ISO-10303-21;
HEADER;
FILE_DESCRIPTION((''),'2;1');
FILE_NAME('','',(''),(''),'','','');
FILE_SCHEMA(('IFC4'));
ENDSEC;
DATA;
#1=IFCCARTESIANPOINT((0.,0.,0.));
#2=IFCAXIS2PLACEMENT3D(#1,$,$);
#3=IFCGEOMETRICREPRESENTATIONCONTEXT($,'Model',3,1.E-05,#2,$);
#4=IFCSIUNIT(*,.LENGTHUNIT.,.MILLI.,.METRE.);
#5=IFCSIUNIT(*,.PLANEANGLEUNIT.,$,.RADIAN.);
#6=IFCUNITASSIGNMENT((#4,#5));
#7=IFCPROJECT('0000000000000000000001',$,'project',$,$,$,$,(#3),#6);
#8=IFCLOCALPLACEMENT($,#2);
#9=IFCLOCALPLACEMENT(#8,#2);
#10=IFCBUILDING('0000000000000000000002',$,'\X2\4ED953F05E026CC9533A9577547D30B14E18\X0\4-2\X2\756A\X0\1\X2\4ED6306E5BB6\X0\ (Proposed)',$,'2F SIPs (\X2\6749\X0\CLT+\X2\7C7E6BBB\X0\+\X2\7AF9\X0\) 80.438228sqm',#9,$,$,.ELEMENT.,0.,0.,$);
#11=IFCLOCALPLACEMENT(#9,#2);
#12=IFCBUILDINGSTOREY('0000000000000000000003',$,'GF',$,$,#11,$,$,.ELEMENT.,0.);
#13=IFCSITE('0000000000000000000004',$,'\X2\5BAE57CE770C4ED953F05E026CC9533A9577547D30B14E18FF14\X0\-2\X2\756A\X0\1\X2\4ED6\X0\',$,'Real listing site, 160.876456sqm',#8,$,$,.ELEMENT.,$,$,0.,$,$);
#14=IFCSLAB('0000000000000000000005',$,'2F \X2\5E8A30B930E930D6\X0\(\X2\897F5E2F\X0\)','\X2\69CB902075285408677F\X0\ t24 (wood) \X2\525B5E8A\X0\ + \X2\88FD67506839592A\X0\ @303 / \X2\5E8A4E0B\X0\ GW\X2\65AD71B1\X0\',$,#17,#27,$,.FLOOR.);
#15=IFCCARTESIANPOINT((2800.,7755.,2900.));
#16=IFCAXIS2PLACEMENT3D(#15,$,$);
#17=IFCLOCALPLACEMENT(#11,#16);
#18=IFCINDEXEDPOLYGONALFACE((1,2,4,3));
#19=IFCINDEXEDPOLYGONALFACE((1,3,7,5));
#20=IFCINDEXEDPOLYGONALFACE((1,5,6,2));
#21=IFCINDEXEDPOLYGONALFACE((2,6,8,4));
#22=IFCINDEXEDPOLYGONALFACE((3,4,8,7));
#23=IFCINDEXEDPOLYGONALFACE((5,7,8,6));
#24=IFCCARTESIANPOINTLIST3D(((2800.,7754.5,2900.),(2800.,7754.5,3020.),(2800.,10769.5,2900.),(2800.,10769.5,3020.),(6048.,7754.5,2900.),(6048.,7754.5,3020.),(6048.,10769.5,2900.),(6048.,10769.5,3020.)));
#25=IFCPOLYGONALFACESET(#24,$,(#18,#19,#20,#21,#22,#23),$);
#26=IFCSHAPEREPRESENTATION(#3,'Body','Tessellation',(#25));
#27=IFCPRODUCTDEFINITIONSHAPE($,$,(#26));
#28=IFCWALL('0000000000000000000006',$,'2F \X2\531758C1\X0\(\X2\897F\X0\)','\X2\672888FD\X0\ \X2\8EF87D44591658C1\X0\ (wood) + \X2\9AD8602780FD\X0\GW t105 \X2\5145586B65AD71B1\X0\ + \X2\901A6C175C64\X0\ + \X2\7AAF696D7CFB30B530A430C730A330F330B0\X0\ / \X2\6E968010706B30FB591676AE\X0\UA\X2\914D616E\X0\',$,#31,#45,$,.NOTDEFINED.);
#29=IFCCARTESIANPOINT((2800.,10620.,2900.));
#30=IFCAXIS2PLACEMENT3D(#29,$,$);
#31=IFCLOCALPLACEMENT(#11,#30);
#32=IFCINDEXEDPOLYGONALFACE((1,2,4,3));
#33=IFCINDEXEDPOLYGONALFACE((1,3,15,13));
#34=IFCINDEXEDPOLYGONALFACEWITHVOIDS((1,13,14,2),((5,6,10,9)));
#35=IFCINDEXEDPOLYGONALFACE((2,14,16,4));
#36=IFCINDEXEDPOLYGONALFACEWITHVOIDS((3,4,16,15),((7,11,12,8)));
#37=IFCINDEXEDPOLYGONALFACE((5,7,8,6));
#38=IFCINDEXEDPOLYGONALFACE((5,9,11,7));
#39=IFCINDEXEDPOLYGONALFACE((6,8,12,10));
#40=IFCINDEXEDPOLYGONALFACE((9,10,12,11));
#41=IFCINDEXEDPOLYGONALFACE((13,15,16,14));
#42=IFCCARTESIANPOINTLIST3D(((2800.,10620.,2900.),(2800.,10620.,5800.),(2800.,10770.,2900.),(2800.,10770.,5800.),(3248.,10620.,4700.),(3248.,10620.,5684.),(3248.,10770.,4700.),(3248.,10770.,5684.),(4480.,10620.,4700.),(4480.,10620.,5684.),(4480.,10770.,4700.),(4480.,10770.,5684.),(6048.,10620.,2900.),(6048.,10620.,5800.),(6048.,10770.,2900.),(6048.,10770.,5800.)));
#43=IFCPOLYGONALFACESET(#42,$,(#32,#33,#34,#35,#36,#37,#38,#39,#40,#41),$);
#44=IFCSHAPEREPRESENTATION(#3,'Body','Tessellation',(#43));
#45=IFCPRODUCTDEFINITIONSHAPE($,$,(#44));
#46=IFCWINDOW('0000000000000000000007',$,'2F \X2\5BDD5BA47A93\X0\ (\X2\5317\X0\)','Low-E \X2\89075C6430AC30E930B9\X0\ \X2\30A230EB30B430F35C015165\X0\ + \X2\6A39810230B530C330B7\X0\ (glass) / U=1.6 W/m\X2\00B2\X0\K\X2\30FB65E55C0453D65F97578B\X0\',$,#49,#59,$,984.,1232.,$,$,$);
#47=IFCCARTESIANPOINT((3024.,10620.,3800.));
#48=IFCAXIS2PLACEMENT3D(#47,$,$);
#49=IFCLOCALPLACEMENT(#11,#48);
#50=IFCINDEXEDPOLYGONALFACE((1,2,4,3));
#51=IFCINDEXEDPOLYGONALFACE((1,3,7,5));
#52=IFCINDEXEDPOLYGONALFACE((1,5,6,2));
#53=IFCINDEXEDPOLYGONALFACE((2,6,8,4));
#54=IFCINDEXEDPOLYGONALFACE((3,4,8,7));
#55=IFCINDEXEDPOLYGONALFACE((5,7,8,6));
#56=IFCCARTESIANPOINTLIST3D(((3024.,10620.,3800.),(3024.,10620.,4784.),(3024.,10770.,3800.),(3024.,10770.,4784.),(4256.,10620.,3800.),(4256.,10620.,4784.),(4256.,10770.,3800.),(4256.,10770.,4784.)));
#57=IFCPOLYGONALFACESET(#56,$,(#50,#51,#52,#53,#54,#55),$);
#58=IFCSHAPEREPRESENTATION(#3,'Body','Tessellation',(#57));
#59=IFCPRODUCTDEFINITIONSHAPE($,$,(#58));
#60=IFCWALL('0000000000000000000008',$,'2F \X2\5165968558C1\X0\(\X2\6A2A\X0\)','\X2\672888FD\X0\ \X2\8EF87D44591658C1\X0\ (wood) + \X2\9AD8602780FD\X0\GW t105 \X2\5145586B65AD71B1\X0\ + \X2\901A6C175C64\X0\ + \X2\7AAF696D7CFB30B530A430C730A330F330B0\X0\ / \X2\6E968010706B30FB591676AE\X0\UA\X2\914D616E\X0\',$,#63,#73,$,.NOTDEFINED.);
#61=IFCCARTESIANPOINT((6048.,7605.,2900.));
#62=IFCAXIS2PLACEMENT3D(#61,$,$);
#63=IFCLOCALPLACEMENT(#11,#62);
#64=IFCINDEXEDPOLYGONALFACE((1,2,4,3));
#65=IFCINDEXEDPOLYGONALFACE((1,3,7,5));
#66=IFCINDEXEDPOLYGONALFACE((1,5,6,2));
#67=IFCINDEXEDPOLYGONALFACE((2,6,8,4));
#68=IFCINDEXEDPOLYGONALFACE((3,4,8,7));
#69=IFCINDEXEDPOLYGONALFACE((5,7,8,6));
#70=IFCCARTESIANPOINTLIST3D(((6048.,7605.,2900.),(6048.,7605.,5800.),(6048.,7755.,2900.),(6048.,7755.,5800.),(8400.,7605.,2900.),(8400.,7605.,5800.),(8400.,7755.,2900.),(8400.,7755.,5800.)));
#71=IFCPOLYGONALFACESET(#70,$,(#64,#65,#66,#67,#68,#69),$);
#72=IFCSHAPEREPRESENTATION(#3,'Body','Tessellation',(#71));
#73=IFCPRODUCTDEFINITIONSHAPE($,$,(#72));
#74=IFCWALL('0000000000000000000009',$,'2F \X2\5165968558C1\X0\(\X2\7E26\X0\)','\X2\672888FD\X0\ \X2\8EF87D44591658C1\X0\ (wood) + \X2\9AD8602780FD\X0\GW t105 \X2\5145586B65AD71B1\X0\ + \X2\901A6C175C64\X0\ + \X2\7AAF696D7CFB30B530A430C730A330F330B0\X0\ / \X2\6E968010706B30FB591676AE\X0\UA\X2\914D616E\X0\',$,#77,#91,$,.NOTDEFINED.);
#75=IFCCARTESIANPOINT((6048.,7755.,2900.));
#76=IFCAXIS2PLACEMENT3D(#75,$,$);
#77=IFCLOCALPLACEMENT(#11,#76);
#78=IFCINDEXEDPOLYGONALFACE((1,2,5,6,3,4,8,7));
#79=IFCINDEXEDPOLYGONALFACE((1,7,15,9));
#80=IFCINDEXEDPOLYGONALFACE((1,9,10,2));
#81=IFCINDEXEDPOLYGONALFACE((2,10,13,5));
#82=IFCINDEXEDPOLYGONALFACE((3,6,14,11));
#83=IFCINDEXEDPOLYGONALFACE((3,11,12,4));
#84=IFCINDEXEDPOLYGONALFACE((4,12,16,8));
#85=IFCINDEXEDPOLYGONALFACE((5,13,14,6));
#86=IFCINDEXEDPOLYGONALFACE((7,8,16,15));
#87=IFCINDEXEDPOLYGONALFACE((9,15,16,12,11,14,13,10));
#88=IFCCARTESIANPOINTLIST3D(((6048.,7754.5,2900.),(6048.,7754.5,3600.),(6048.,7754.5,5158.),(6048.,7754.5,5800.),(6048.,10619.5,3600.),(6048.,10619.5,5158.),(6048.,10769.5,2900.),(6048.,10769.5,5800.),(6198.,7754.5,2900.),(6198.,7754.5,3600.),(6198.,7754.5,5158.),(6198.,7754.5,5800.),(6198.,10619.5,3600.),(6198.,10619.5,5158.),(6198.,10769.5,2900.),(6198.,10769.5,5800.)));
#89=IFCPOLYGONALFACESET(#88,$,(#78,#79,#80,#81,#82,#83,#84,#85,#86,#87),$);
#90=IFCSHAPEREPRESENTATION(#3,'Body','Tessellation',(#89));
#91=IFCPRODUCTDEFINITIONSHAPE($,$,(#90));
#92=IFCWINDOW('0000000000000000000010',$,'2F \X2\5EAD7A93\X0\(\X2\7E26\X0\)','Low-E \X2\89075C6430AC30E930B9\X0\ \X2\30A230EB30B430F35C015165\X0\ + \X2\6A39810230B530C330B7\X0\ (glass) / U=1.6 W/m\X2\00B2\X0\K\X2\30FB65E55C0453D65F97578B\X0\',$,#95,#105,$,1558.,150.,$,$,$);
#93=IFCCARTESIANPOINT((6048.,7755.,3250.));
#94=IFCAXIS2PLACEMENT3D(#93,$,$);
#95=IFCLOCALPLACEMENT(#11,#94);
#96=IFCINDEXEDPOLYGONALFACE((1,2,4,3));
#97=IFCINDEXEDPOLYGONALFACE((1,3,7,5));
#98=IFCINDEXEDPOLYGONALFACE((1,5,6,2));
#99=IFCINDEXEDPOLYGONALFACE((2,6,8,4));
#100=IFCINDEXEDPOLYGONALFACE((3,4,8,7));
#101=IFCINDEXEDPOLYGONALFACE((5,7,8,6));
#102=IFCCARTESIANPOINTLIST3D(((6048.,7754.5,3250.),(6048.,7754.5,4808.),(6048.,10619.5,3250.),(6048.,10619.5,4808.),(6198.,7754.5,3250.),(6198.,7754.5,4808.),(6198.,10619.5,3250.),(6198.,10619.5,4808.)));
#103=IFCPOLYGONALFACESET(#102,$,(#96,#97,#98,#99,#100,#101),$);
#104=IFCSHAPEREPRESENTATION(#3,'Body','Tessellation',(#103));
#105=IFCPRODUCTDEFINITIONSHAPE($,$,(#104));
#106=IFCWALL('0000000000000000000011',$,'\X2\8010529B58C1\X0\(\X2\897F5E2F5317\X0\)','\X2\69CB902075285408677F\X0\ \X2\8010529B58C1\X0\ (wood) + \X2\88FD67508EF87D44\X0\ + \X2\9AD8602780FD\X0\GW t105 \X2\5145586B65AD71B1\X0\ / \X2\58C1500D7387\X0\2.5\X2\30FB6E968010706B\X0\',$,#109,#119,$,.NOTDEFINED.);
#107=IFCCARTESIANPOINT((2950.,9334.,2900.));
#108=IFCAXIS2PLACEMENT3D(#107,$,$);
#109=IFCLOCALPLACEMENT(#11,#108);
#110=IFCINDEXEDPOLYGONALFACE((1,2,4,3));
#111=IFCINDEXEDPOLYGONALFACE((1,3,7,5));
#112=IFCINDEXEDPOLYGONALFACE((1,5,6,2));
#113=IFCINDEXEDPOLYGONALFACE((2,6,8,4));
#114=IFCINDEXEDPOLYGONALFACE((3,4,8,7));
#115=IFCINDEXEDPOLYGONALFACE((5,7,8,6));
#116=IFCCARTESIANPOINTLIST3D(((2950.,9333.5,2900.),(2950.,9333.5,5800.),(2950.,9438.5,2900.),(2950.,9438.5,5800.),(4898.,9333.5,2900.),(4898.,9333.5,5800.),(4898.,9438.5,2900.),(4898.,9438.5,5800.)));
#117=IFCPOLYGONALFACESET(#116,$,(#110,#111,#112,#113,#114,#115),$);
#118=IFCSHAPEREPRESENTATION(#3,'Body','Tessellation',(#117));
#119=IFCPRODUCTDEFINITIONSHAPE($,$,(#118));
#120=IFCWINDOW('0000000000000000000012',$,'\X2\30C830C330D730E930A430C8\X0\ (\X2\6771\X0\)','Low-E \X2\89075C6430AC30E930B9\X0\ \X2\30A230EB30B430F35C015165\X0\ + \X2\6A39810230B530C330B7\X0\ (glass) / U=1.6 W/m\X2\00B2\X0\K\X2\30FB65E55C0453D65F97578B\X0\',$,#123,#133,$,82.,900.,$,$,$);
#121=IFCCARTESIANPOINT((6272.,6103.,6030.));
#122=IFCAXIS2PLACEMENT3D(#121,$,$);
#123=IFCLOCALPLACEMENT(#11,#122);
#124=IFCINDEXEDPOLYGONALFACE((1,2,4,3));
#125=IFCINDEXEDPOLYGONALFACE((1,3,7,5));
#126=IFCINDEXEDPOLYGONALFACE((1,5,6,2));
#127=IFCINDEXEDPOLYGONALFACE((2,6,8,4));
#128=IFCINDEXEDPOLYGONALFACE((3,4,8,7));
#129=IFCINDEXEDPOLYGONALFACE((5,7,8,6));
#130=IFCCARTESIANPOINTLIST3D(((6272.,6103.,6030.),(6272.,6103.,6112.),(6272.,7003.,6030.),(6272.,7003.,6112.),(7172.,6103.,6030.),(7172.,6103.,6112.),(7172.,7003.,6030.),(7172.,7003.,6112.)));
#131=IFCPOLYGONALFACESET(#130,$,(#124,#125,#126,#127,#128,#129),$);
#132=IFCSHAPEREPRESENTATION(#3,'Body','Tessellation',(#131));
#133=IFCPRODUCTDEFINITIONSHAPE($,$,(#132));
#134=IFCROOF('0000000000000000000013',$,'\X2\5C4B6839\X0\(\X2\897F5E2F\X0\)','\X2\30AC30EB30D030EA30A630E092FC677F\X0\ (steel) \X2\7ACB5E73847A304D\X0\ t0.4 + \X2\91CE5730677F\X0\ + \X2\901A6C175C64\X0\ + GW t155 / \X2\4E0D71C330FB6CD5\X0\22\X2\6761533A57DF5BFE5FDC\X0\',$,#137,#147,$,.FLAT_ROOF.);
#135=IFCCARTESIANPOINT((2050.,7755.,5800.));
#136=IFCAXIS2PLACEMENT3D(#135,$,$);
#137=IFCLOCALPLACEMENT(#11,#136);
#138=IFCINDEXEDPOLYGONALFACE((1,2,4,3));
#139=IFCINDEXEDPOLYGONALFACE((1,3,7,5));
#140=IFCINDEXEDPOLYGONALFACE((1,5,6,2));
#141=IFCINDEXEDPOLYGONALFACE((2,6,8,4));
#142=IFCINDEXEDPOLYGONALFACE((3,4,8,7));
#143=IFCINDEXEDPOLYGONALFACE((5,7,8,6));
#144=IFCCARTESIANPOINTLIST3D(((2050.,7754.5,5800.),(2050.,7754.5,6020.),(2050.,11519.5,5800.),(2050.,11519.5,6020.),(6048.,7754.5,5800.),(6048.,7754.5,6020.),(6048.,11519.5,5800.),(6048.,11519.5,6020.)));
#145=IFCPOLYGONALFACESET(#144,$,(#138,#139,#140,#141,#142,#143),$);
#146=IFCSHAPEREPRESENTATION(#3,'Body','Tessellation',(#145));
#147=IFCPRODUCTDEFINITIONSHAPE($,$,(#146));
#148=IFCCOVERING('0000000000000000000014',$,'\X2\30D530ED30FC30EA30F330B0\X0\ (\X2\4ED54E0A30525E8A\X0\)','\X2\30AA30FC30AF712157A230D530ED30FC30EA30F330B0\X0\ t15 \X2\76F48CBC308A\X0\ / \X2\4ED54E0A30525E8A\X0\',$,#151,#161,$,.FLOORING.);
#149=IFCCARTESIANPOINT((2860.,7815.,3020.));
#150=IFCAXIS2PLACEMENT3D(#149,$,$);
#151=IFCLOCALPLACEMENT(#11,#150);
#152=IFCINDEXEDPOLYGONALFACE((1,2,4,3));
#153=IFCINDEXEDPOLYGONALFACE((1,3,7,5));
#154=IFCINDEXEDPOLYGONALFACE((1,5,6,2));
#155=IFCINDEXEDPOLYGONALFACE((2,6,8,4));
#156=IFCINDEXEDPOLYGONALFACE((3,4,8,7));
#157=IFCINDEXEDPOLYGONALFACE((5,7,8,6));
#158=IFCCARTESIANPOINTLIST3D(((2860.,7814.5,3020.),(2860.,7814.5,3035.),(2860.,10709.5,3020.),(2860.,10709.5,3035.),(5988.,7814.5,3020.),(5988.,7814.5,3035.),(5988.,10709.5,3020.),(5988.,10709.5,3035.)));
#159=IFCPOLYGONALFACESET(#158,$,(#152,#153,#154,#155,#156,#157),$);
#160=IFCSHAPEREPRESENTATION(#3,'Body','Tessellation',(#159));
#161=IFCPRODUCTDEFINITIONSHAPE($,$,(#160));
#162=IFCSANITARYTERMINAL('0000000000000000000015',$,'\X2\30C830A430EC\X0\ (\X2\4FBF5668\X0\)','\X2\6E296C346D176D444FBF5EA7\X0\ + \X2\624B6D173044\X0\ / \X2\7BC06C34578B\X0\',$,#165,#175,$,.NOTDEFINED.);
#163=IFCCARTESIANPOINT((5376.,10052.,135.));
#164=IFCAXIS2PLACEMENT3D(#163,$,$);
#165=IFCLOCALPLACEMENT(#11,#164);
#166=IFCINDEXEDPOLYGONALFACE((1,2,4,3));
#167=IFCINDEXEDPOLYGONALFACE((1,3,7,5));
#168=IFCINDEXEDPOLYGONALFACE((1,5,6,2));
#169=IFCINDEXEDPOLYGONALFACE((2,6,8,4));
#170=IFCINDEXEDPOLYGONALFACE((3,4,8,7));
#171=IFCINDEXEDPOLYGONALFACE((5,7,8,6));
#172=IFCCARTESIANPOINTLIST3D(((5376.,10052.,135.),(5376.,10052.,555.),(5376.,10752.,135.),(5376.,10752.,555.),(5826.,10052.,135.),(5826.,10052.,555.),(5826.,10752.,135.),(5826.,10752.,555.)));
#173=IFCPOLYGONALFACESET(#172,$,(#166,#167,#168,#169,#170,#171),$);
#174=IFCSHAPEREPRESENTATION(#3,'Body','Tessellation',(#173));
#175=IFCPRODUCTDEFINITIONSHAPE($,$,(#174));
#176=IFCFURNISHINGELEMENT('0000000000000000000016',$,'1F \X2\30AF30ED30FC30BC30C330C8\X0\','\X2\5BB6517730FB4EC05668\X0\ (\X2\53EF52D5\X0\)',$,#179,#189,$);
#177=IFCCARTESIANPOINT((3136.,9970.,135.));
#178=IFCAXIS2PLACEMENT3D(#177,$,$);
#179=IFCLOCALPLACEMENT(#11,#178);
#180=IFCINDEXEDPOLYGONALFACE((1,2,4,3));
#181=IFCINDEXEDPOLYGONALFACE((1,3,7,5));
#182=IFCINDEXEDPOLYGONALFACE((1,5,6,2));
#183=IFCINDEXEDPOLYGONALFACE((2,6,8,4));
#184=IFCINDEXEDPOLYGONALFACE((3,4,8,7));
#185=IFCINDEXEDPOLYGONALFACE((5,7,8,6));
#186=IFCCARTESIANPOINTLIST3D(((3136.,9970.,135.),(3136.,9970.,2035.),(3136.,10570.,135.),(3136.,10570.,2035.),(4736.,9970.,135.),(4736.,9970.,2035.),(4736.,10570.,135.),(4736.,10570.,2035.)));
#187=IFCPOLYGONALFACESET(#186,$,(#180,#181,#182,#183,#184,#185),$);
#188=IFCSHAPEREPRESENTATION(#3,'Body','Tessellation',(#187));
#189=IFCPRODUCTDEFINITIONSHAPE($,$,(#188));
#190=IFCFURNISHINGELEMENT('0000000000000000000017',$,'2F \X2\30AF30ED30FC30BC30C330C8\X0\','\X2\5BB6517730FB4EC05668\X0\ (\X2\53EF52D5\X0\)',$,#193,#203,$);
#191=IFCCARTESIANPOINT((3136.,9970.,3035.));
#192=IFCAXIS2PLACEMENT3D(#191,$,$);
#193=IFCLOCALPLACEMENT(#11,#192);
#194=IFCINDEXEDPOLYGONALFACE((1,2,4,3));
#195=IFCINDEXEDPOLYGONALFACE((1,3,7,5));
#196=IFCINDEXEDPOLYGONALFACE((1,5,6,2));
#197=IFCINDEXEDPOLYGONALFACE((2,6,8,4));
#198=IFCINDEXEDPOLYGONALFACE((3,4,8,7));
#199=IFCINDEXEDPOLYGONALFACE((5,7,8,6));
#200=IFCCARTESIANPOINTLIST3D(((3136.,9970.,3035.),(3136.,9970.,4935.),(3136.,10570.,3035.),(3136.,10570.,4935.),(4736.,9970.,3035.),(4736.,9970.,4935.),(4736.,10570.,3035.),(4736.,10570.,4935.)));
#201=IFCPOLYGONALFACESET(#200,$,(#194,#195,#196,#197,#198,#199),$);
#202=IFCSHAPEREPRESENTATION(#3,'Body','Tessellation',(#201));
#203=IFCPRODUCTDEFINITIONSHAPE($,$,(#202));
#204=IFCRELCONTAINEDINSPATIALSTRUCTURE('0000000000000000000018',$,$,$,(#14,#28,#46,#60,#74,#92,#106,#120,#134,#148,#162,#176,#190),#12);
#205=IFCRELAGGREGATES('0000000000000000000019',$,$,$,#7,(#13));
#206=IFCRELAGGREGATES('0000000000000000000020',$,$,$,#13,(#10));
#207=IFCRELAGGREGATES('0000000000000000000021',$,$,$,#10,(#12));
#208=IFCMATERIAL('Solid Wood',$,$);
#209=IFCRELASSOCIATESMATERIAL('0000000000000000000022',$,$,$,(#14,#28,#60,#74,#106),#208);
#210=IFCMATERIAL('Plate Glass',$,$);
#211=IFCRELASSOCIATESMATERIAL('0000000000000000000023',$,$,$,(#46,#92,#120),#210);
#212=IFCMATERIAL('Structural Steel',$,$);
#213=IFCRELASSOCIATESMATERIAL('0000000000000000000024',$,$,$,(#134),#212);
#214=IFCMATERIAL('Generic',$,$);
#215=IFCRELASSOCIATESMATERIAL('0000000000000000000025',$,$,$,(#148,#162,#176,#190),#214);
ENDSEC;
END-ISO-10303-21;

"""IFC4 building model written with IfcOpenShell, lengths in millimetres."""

from ifc_helpers import new_model, si_unit, frame, frame_2d, origin, place, context, project, spatial, rectangle, extrude, material, element, fill, save


model = new_model("IFC4")

# Units and contexts
model_context = context("Model", 3, precision=1e-05, world=origin())
ifc_project = project(units=[si_unit("LENGTHUNIT", "METRE", prefix="MILLI"), si_unit("PLANEANGLEUNIT", "RADIAN")], contexts=[model_context])

# Site, building, storey
site_placement = place(None, origin())
site = spatial("IfcSite", under=ifc_project, at=site_placement, Name="宮城県仙台市泉区長命ケ丘４-2番1他", ObjectType="Real listing site, 160.876456sqm", CompositionType="ELEMENT", RefElevation=0.0)
building_placement = place(site_placement, origin())
building = spatial("IfcBuilding", under=site, at=building_placement, Name="仙台市泉区長命ケ丘4-2番1他の家 (Proposed)", ObjectType="2F SIPs (杉CLT+籾殻+竹) 80.438228sqm", CompositionType="ELEMENT", ElevationOfRefHeight=0.0, ElevationOfTerrain=0.0)
storey_placement = place(building_placement, origin())
storey = spatial("IfcBuildingStorey", under=building, at=storey_placement, Name="GF", CompositionType="ELEMENT", Elevation=0.0)

# Slab
ifc_material_1 = material(Name="Solid Wood")
slab_placement = place(storey_placement, frame((2800.0, 7755.0, 2900.0)))
element("IfcSlab", 1, at=slab_placement, inside=storey, material=ifc_material_1, Name="2F 床スラブ(西帯)", Description="構造用合板 t24 (wood) 剛床 + 製材根太 @303 / 床下 GW断熱", PredefinedType="FLOOR", context=model_context, shape_type="SweptSolid", body=[
    extrude(rectangle(XDim=3248.0, YDim=3015.0, at=frame_2d((1624.0, 1507.0))), frame((2800.0, 7755.0, 2900.0)), (0.0, 0.0, 1.0), 120.0),
])

# Wall, opening, window
wall_1_placement = place(storey_placement, frame((2800.0, 10620.0, 2900.0)))
wall_1 = element("IfcWall", 2, at=wall_1_placement, inside=storey, material=ifc_material_1, Name="2F 北壁(西)", Description="木製 軸組外壁 (wood) + 高性能GW t105 充填断熱 + 通気層 + 窯業系サイディング / 準耐火・外皮UA配慮", PredefinedType="NOTDEFINED", context=model_context, shape_type="SweptSolid", body=[
    extrude(rectangle(XDim=3248.0, YDim=150.0, at=frame_2d((1624.0, 75.0))), frame((2800.0, 10620.0, 2900.0)), (0.0, 0.0, 1.0), 2900.0),
])
opening_1_placement = place(storey_placement, frame((3024.0, 10620.0, 3800.0)))
opening_1 = element("IfcOpeningElement", 3, at=opening_1_placement, cuts=wall_1, PredefinedType="NOTDEFINED", context=model_context, shape_type="SweptSolid", body=[
    extrude(rectangle(XDim=1232.0, YDim=150.0, at=frame_2d((616.0, 75.0))), frame((3024.0, 10620.0, 3800.0)), (0.0, 0.0, 1.0), 984.0),
])
ifc_material_2 = material(Name="Plate Glass")
window_1_placement = place(storey_placement, frame((3024.0, 10620.0, 3800.0)))
window_1 = element("IfcWindow", 4, at=window_1_placement, inside=storey, material=ifc_material_2, Name="2F 寝室窓 (北)", Description="Low-E 複層ガラス アルゴン封入 + 樹脂サッシ (glass) / U=1.6 W/m²K・日射取得型", OverallHeight=984.0, OverallWidth=1232.0, context=model_context, shape_type="SweptSolid", body=[
    extrude(rectangle(XDim=1232.0, YDim=150.0, at=frame_2d((616.0, 75.0))), frame((3024.0, 10620.0, 3800.0)), (0.0, 0.0, 1.0), 984.0),
])
fill(opening_1, window_1)

# Wall
wall_2_placement = place(storey_placement, frame((6048.0, 7605.0, 2900.0)))
element("IfcWall", 5, at=wall_2_placement, inside=storey, material=ifc_material_1, Name="2F 入隅壁(横)", Description="木製 軸組外壁 (wood) + 高性能GW t105 充填断熱 + 通気層 + 窯業系サイディング / 準耐火・外皮UA配慮", PredefinedType="NOTDEFINED", context=model_context, shape_type="SweptSolid", body=[
    extrude(rectangle(XDim=2352.0, YDim=150.0, at=frame_2d((1176.0, 75.0))), frame((6048.0, 7605.0, 2900.0)), (0.0, 0.0, 1.0), 2900.0),
])

# Wall, opening, window
wall_3_placement = place(storey_placement, frame((6048.0, 7755.0, 2900.0)))
wall_3 = element("IfcWall", 6, at=wall_3_placement, inside=storey, material=ifc_material_1, Name="2F 入隅壁(縦)", Description="木製 軸組外壁 (wood) + 高性能GW t105 充填断熱 + 通気層 + 窯業系サイディング / 準耐火・外皮UA配慮", PredefinedType="NOTDEFINED", context=model_context, shape_type="SweptSolid", body=[
    extrude(rectangle(XDim=150.0, YDim=3015.0, at=frame_2d((75.0, 1507.0))), frame((6048.0, 7755.0, 2900.0)), (0.0, 0.0, 1.0), 2900.0),
])
opening_2_placement = place(storey_placement, frame((6048.0, 7755.0, 3250.0)))
opening_2 = element("IfcOpeningElement", 7, at=opening_2_placement, cuts=wall_3, PredefinedType="NOTDEFINED", context=model_context, shape_type="SweptSolid", body=[
    extrude(rectangle(XDim=150.0, YDim=2865.0, at=frame_2d((75.0, 1432.0))), frame((6048.0, 7755.0, 3250.0)), (0.0, 0.0, 1.0), 1558.0),
])
window_2_placement = place(storey_placement, frame((6048.0, 7755.0, 3250.0)))
window_2 = element("IfcWindow", 8, at=window_2_placement, inside=storey, material=ifc_material_2, Name="2F 庭窓(縦)", Description="Low-E 複層ガラス アルゴン封入 + 樹脂サッシ (glass) / U=1.6 W/m²K・日射取得型", OverallHeight=1558.0, OverallWidth=150.0, context=model_context, shape_type="SweptSolid", body=[
    extrude(rectangle(XDim=150.0, YDim=2865.0, at=frame_2d((75.0, 1432.0))), frame((6048.0, 7755.0, 3250.0)), (0.0, 0.0, 1.0), 1558.0),
])
fill(opening_2, window_2)

# Wall
wall_4_placement = place(storey_placement, frame((2950.0, 9334.0, 2900.0)))
element("IfcWall", 9, at=wall_4_placement, inside=storey, material=ifc_material_1, Name="耐力壁(西帯北)", Description="構造用合板 耐力壁 (wood) + 製材軸組 + 高性能GW t105 充填断熱 / 壁倍率2.5・準耐火", PredefinedType="NOTDEFINED", context=model_context, shape_type="SweptSolid", body=[
    extrude(rectangle(XDim=1948.0, YDim=105.0, at=frame_2d((974.0, 52.0))), frame((2950.0, 9334.0, 2900.0)), (0.0, 0.0, 1.0), 2900.0),
])

# Window
window_3_placement = place(storey_placement, frame((6272.0, 6103.0, 6030.0)))
element("IfcWindow", 10, at=window_3_placement, inside=storey, material=ifc_material_2, Name="トップライト (東)", Description="Low-E 複層ガラス アルゴン封入 + 樹脂サッシ (glass) / U=1.6 W/m²K・日射取得型", OverallHeight=82.0, OverallWidth=900.0, context=model_context, shape_type="SweptSolid", body=[
    extrude(rectangle(XDim=900.0, YDim=900.0, at=frame_2d((450.0, 450.0))), frame((6272.0, 6103.0, 6030.0)), (0.0, 0.0, 1.0), 82.0),
])

# Roof
ifc_material_3 = material(Name="Structural Steel")
for number, where, name in (
    (11, (2050.0, 7755.0, 5800.0), "屋根(西帯)"),
):
    element("IfcRoof", number, at=place(storey_placement, frame(where)), inside=storey, material=ifc_material_3, Name=name, Description="ガルバリウム鋼板 (steel) 立平葺き t0.4 + 野地板 + 通気層 + GW t155 / 不燃・法22条区域対応", PredefinedType="FLAT_ROOF", context=model_context, shape_type="SweptSolid", body=[
        extrude(rectangle(XDim=3998.0, YDim=3765.0, at=frame_2d((1999.0, 1882.0))), frame((2050.0, 7755.0, 5800.0)), (0.0, 0.0, 1.0), 220.0),
    ])

# Covering
ifc_material_4 = material(Name="Generic")
covering_placement = place(storey_placement, frame((2860.0, 7815.0, 3020.0)))
element("IfcCovering", 12, at=covering_placement, inside=storey, material=ifc_material_4, Name="フローリング (仕上げ床)", Description="オーク無垢フローリング t15 直貼り / 仕上げ床", PredefinedType="FLOORING", context=model_context, shape_type="SweptSolid", body=[
    extrude(rectangle(XDim=3128.0, YDim=2895.0, at=frame_2d((1564.0, 1447.0))), frame((2860.0, 7815.0, 3020.0)), (0.0, 0.0, 1.0), 15.0),
])

# Sanitary terminal
sanitary_terminal_placement = place(storey_placement, frame((5376.0, 10052.0, 135.0)))
element("IfcSanitaryTerminal", 13, at=sanitary_terminal_placement, inside=storey, material=ifc_material_4, Name="トイレ (便器)", Description="温水洗浄便座 + 手洗い / 節水型", PredefinedType="NOTDEFINED", context=model_context, shape_type="SweptSolid", body=[
    extrude(rectangle(XDim=450.0, YDim=700.0, at=frame_2d((225.0, 350.0))), frame((5376.0, 10052.0, 135.0)), (0.0, 0.0, 1.0), 420.0),
])

# Furnishing elements
furnishing_1_placement = place(storey_placement, frame((3136.0, 9970.0, 135.0)))
element("IfcFurnishingElement", 14, at=furnishing_1_placement, inside=storey, material=ifc_material_4, Name="1F クローゼット", Description="家具・什器 (可動)", context=model_context, shape_type="SweptSolid", body=[
    extrude(rectangle(XDim=1600.0, YDim=600.0, at=frame_2d((800.0, 300.0))), frame((3136.0, 9970.0, 135.0)), (0.0, 0.0, 1.0), 1900.0),
])
furnishing_2_placement = place(storey_placement, frame((3136.0, 9970.0, 3035.0)))
element("IfcFurnishingElement", 15, at=furnishing_2_placement, inside=storey, material=ifc_material_4, Name="2F クローゼット", Description="家具・什器 (可動)", context=model_context, shape_type="SweptSolid", body=[
    extrude(rectangle(XDim=1600.0, YDim=600.0, at=frame_2d((800.0, 300.0))), frame((3136.0, 9970.0, 3035.0)), (0.0, 0.0, 1.0), 1900.0),
])

save(model, "model.ifc")
